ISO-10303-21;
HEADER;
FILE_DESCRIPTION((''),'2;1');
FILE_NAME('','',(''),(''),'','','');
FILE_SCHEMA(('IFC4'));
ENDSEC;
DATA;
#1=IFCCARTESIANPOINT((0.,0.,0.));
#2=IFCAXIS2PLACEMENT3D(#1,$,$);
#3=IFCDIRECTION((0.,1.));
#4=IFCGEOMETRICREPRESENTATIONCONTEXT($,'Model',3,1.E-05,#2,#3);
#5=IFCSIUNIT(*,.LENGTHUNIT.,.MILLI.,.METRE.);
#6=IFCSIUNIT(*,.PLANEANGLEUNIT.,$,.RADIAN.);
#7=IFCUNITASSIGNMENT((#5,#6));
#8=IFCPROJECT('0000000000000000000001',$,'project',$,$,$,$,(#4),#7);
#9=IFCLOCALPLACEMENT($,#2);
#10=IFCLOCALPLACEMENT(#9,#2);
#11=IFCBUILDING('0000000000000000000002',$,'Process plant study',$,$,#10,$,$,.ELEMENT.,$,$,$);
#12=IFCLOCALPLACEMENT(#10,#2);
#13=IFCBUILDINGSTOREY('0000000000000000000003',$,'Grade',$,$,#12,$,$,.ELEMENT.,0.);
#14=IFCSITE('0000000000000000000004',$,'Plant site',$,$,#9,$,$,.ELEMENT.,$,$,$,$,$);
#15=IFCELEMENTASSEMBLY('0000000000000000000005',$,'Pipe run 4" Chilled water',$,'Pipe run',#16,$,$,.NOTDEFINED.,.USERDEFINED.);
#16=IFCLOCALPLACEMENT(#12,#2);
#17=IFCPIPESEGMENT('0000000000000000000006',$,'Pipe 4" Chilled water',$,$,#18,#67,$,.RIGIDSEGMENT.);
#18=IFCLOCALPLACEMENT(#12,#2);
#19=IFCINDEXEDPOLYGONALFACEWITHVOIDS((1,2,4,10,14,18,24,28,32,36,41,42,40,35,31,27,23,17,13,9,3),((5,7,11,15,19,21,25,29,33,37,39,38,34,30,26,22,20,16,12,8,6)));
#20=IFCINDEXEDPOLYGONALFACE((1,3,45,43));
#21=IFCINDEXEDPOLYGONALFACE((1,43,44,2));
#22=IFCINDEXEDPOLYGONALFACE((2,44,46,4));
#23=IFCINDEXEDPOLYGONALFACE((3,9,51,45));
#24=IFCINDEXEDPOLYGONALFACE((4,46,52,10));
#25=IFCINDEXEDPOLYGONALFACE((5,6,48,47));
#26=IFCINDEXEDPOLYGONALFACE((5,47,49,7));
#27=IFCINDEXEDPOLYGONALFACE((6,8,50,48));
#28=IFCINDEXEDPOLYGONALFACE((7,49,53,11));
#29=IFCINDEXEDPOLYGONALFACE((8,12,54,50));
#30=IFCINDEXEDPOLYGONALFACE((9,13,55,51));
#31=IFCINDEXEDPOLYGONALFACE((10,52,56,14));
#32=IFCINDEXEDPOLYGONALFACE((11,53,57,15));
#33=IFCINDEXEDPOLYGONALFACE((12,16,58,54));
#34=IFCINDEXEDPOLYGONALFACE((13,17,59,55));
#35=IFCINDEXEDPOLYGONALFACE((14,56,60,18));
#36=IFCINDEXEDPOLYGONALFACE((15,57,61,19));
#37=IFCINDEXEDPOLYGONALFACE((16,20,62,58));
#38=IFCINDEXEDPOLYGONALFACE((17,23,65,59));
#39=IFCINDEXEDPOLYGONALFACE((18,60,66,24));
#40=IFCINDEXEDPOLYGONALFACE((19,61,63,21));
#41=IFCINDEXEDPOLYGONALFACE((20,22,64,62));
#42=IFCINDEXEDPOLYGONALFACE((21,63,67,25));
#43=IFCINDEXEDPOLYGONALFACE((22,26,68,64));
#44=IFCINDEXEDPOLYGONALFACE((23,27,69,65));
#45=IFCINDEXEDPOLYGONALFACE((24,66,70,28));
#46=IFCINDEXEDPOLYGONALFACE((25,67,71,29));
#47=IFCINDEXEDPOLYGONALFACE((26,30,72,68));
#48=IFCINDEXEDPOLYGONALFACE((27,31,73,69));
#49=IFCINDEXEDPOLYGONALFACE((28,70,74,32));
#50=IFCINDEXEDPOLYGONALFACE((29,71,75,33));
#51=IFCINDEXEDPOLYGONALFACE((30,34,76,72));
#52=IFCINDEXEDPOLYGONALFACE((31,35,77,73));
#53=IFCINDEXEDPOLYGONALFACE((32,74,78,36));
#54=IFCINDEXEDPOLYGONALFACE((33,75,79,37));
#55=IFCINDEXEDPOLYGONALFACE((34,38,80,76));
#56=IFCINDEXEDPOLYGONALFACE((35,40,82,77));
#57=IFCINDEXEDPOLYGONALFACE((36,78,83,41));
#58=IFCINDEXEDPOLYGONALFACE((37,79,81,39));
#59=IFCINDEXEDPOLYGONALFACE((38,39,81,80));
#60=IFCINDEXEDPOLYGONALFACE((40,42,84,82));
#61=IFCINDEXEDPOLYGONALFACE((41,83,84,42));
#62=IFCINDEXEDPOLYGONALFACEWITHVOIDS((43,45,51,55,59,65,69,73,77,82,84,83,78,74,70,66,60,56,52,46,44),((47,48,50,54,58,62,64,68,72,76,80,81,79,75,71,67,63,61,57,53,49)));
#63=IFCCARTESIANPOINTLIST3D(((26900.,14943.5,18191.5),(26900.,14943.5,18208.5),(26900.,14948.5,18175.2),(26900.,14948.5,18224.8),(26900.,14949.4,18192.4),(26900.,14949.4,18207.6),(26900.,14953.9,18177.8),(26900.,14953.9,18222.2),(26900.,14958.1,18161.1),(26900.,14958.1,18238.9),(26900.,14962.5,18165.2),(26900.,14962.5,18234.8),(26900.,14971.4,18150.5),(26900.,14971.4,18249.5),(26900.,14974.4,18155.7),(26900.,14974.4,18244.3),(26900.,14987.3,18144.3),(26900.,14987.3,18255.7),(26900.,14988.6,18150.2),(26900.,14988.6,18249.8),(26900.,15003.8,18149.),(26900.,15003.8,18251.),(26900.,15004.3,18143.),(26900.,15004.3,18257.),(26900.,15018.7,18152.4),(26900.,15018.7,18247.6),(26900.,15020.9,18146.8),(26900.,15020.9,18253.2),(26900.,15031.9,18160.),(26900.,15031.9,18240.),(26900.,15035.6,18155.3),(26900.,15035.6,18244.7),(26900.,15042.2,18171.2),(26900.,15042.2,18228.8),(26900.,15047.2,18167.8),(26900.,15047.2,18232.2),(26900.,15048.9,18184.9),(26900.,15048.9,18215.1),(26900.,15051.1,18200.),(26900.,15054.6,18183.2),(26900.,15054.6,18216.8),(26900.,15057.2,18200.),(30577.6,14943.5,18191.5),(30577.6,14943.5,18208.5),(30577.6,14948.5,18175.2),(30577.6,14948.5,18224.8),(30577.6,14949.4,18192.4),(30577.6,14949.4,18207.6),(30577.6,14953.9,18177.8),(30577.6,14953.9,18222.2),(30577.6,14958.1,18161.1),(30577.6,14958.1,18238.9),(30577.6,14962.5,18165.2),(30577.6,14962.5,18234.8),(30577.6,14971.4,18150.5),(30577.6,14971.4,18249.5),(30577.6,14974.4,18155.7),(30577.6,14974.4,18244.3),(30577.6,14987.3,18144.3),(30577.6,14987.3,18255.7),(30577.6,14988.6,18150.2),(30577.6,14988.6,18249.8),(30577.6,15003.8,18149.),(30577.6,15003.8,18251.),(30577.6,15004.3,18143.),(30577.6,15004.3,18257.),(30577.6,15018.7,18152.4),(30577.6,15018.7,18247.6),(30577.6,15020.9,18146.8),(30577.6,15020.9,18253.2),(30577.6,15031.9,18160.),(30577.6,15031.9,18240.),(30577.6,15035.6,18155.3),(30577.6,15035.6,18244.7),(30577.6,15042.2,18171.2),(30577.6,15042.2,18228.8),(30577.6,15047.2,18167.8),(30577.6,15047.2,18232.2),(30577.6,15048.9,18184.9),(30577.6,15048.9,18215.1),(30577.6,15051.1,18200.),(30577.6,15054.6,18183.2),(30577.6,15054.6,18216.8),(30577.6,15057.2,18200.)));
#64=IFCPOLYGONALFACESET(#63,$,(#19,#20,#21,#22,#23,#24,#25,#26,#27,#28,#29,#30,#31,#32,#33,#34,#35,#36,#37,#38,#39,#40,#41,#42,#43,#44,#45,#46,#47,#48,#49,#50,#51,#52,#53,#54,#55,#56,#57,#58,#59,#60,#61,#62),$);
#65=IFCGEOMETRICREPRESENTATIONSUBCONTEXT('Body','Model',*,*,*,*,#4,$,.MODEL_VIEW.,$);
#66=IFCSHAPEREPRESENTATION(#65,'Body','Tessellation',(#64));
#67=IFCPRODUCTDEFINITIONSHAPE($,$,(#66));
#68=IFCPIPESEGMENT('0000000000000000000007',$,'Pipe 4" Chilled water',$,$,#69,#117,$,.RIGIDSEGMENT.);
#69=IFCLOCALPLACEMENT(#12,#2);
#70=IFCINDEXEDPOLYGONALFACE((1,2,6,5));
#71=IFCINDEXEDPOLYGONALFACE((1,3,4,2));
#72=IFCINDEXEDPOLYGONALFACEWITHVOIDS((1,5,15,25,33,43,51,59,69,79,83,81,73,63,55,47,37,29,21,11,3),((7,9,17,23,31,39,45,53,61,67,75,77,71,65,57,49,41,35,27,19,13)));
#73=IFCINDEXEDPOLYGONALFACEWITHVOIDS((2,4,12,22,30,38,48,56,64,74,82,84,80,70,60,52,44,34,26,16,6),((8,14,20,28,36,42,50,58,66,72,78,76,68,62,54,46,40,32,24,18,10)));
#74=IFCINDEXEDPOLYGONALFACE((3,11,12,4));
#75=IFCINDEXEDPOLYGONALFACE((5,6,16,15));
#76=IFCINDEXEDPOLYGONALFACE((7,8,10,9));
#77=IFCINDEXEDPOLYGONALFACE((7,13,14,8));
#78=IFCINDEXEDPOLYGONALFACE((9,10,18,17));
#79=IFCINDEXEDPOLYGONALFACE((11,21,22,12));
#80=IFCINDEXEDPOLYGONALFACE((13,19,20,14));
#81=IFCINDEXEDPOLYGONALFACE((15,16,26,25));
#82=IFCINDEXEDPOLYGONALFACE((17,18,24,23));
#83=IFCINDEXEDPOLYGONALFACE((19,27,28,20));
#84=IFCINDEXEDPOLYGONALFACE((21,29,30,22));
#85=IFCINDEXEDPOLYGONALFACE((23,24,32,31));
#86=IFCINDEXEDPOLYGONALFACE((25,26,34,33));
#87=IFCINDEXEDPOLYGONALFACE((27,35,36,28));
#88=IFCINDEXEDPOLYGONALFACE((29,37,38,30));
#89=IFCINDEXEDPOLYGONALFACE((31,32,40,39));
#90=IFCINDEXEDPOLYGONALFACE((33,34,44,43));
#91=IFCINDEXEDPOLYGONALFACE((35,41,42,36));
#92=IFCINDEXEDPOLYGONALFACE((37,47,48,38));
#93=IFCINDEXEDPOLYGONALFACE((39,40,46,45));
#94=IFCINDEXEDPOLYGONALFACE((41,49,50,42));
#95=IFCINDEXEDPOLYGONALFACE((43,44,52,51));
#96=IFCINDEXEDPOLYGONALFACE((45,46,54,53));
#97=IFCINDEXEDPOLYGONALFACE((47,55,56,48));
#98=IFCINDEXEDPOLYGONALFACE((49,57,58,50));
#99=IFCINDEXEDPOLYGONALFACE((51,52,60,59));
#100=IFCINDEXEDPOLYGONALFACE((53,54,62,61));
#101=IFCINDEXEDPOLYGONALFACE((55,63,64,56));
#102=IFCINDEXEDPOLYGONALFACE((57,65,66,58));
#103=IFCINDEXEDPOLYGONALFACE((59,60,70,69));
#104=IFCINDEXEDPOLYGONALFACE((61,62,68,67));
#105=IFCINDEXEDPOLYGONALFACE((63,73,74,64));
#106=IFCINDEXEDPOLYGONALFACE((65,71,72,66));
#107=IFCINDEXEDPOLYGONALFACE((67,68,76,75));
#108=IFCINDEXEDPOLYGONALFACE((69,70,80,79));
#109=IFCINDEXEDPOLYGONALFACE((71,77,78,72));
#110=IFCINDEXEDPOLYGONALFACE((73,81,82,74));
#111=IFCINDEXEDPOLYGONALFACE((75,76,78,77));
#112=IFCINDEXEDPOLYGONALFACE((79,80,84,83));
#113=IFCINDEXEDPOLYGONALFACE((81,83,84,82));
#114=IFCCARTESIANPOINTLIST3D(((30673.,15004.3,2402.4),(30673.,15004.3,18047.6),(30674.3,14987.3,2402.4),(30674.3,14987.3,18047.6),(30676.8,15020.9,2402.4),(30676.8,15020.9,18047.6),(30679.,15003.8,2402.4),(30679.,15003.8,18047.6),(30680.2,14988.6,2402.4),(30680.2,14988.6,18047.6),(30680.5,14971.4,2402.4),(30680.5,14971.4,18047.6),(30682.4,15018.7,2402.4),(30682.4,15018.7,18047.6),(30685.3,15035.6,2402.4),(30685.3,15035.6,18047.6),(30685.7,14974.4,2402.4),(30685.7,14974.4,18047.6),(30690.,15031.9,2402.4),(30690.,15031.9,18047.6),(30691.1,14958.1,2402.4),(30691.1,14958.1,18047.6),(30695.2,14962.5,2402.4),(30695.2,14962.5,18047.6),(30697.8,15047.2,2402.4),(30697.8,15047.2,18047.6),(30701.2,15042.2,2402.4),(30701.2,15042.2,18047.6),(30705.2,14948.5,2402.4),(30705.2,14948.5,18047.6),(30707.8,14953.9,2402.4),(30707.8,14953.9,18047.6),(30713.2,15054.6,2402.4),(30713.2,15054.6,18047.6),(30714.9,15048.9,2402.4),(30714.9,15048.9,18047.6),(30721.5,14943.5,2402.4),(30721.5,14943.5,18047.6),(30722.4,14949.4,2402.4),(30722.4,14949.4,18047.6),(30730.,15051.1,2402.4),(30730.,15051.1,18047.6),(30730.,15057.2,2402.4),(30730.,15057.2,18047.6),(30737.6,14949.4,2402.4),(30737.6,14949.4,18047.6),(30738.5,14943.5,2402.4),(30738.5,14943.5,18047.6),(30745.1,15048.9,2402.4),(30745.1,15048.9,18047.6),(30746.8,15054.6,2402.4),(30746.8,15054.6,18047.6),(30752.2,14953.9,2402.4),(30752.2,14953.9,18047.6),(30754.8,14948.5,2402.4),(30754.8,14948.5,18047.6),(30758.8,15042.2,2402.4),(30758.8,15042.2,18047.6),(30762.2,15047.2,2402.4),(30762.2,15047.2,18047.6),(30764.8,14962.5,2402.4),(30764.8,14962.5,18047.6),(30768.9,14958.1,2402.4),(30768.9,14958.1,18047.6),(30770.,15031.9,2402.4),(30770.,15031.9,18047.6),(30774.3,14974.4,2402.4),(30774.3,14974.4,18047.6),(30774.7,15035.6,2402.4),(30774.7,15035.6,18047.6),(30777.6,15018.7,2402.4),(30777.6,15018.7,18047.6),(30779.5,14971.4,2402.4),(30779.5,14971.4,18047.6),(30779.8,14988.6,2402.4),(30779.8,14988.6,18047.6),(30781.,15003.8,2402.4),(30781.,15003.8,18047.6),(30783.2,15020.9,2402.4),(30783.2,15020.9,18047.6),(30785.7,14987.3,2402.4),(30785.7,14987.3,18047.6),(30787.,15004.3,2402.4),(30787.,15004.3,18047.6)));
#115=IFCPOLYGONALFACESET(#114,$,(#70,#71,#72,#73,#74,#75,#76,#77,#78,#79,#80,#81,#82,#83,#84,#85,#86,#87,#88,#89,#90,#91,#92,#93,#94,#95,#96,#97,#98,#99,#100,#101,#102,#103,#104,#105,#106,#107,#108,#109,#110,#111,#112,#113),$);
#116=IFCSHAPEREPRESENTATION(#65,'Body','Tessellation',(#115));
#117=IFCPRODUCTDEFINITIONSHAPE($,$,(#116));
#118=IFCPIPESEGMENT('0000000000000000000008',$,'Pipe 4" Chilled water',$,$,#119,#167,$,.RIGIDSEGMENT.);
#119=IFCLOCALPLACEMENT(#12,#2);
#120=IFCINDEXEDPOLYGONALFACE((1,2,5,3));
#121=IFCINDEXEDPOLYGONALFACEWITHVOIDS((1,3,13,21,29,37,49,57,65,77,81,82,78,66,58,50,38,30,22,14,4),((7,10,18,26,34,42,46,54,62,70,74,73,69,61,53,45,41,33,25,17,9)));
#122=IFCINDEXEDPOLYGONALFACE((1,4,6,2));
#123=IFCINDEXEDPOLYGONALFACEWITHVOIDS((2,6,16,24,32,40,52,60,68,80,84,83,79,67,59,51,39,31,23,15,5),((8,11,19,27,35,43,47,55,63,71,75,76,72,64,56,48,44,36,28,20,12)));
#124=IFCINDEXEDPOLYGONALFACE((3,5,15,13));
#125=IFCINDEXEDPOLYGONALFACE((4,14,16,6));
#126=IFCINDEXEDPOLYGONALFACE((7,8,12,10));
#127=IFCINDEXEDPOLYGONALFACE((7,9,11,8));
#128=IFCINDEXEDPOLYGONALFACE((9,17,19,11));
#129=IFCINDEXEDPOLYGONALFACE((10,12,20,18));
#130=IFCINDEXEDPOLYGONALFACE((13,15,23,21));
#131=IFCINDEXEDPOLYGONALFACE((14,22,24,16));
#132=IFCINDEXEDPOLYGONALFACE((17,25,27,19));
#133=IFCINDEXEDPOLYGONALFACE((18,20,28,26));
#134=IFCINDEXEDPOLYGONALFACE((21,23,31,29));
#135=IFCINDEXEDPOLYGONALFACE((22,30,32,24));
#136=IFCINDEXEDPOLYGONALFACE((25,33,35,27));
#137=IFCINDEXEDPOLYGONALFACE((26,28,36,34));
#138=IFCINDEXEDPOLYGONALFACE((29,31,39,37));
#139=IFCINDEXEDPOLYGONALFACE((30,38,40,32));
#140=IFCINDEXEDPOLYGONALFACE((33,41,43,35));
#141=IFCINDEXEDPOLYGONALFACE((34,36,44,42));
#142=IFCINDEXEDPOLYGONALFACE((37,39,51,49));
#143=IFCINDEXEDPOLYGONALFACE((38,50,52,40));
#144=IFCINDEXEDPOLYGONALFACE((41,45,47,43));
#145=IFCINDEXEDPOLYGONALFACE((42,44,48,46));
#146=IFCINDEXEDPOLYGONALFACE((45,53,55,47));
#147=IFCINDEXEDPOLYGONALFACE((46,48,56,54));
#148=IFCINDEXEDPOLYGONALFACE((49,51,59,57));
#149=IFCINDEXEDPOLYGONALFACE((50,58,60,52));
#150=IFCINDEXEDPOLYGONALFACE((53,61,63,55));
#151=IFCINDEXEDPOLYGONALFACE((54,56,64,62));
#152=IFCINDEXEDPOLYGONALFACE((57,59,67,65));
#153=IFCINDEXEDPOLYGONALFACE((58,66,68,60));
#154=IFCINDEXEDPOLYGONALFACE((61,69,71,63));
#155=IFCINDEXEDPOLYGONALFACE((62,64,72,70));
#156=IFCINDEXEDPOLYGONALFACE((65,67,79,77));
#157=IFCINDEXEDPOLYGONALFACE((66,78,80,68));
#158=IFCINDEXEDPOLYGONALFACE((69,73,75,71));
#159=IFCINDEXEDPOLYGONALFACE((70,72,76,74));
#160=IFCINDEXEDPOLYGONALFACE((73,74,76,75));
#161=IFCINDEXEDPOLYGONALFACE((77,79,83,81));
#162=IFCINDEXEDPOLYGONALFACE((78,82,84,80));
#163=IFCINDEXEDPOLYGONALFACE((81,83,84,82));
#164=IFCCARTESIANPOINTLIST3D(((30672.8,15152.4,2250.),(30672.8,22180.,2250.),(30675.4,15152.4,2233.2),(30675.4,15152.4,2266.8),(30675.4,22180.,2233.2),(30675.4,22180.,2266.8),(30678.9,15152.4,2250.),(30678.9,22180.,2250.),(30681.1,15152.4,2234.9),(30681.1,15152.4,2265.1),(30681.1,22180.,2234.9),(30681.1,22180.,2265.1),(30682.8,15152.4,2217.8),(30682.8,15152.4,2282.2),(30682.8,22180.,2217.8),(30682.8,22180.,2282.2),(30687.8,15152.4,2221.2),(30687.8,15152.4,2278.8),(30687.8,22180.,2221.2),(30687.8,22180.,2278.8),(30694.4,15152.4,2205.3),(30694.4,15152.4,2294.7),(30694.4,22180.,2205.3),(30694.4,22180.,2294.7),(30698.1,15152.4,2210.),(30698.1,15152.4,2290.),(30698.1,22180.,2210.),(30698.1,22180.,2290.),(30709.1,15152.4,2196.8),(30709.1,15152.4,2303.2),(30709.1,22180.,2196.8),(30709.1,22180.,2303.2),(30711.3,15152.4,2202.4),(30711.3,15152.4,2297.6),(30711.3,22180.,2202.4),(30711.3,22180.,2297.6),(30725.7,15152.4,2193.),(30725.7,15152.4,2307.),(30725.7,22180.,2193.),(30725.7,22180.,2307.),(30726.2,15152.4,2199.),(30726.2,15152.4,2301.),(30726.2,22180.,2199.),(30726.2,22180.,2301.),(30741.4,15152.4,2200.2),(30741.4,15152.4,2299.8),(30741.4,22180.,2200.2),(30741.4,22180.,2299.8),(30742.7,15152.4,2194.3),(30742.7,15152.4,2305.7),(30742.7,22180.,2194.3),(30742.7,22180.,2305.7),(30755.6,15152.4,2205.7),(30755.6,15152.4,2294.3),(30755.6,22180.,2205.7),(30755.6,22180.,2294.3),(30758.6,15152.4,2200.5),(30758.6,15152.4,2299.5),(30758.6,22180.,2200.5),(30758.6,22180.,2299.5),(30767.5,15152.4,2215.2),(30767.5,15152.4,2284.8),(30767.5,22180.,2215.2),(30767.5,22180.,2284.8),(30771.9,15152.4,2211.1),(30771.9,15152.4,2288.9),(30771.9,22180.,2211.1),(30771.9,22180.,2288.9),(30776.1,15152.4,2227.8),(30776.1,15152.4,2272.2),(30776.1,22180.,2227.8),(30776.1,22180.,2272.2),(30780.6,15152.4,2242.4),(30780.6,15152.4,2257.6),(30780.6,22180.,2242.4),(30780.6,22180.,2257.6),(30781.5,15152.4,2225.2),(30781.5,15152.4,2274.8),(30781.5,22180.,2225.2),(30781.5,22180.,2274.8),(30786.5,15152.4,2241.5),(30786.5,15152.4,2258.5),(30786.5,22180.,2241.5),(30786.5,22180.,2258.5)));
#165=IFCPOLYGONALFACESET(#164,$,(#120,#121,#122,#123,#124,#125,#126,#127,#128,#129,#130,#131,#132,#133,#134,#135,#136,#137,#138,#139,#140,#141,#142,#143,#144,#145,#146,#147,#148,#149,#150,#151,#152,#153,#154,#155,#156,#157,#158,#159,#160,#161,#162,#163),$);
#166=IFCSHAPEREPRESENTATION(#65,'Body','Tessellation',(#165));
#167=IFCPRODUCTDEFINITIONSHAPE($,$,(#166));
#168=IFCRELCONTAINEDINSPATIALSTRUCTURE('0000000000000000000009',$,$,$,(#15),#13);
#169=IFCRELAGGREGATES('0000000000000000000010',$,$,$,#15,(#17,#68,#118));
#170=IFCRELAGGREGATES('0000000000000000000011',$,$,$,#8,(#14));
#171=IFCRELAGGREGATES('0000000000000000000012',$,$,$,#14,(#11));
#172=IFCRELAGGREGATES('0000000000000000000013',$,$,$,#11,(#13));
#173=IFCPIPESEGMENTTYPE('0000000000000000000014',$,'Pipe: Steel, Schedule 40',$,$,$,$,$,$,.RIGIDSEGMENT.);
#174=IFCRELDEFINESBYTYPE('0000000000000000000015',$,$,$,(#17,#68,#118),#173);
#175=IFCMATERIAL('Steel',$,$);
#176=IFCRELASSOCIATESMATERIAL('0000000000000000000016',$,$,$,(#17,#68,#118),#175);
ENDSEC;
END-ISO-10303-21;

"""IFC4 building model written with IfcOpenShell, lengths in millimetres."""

from ifc_helpers import new_model, si_unit, direction, frame, origin, origin_with_axes, origin_2d, place, context, subcontext, project, spatial, hollow_circle, extrude, material, type_object, element, aggregate, save


model = new_model("IFC4")

# Units and contexts
model_context = context("Model", 3, precision=1e-05, world=origin(), true_north=direction((0.0, 1.0)))
body_context = subcontext(model_context, "Body", "Model", "MODEL_VIEW")
ifc_project = project(units=[si_unit("LENGTHUNIT", "METRE", prefix="MILLI"), si_unit("PLANEANGLEUNIT", "RADIAN")], contexts=[model_context])

# Site, building, storey
site_placement = place(None, origin())
site = spatial("IfcSite", under=ifc_project, at=site_placement, Name="Plant site", CompositionType="ELEMENT")
building_placement = place(site_placement, origin())
building = spatial("IfcBuilding", under=site, at=building_placement, Name="Process plant study", CompositionType="ELEMENT")
storey_placement = place(building_placement, origin())
storey = spatial("IfcBuildingStorey", under=building, at=storey_placement, Name="Grade", CompositionType="ELEMENT", Elevation=0.0)

# Element assembly, pipe segments
assembly_1_placement = place(storey_placement, origin_with_axes())
assembly_1 = element("IfcElementAssembly", 1, at=assembly_1_placement, inside=storey, Name="Pipe run 4\" Chilled water", ObjectType="Pipe run", AssemblyPlace="NOTDEFINED", PredefinedType="USERDEFINED")
ifc_material = material(Name="Steel")
pipe_segment_type = type_object("IfcPipeSegmentType", Name="Pipe: Steel, Schedule 40", PredefinedType="RIGIDSEGMENT")
pipe_segment_1_placement = place(storey_placement, origin_with_axes())
pipe_segment_1 = element("IfcPipeSegment", 2, at=pipe_segment_1_placement, type_object=pipe_segment_type, material=ifc_material, Name="Pipe 4\" Chilled water", PredefinedType="RIGIDSEGMENT", context=body_context, shape_type="SweptSolid", body=[
    extrude(hollow_circle(Radius=57.1, WallThickness=6.0, at=origin_2d()), frame((26900.0, 15000.0, 18200.0), z_axis=(1.0, 0.0, 0.0), x_axis=(0.0, 1.0, 0.0)), (0.0, 0.0, 1.0), 3677.6),
])
pipe_segment_2_placement = place(storey_placement, origin_with_axes())
pipe_segment_2 = element("IfcPipeSegment", 3, at=pipe_segment_2_placement, type_object=pipe_segment_type, material=ifc_material, Name="Pipe 4\" Chilled water", PredefinedType="RIGIDSEGMENT", context=body_context, shape_type="SweptSolid", body=[
    extrude(hollow_circle(Radius=57.1, WallThickness=6.0, at=origin_2d()), frame((30730.0, 15000.0, 18047.6), z_axis=(0.0, 0.0, -1.0), x_axis=(0.0, 1.0, 0.0)), (0.0, 0.0, 1.0), 15645.2),
])
pipe_segment_3_placement = place(storey_placement, origin_with_axes())
pipe_segment_3 = element("IfcPipeSegment", 4, at=pipe_segment_3_placement, type_object=pipe_segment_type, material=ifc_material, Name="Pipe 4\" Chilled water", PredefinedType="RIGIDSEGMENT", context=body_context, shape_type="SweptSolid", body=[
    extrude(hollow_circle(Radius=57.1, WallThickness=6.0, at=origin_2d()), frame((30730.0, 15152.4, 2250.0), z_axis=(0.0, 1.0, 0.0), x_axis=(-1.0, 0.0, 0.0)), (0.0, 0.0, 1.0), 7027.6),
])

aggregate(assembly_1, [pipe_segment_1, pipe_segment_2, pipe_segment_3])

save(model, "model.ifc")
